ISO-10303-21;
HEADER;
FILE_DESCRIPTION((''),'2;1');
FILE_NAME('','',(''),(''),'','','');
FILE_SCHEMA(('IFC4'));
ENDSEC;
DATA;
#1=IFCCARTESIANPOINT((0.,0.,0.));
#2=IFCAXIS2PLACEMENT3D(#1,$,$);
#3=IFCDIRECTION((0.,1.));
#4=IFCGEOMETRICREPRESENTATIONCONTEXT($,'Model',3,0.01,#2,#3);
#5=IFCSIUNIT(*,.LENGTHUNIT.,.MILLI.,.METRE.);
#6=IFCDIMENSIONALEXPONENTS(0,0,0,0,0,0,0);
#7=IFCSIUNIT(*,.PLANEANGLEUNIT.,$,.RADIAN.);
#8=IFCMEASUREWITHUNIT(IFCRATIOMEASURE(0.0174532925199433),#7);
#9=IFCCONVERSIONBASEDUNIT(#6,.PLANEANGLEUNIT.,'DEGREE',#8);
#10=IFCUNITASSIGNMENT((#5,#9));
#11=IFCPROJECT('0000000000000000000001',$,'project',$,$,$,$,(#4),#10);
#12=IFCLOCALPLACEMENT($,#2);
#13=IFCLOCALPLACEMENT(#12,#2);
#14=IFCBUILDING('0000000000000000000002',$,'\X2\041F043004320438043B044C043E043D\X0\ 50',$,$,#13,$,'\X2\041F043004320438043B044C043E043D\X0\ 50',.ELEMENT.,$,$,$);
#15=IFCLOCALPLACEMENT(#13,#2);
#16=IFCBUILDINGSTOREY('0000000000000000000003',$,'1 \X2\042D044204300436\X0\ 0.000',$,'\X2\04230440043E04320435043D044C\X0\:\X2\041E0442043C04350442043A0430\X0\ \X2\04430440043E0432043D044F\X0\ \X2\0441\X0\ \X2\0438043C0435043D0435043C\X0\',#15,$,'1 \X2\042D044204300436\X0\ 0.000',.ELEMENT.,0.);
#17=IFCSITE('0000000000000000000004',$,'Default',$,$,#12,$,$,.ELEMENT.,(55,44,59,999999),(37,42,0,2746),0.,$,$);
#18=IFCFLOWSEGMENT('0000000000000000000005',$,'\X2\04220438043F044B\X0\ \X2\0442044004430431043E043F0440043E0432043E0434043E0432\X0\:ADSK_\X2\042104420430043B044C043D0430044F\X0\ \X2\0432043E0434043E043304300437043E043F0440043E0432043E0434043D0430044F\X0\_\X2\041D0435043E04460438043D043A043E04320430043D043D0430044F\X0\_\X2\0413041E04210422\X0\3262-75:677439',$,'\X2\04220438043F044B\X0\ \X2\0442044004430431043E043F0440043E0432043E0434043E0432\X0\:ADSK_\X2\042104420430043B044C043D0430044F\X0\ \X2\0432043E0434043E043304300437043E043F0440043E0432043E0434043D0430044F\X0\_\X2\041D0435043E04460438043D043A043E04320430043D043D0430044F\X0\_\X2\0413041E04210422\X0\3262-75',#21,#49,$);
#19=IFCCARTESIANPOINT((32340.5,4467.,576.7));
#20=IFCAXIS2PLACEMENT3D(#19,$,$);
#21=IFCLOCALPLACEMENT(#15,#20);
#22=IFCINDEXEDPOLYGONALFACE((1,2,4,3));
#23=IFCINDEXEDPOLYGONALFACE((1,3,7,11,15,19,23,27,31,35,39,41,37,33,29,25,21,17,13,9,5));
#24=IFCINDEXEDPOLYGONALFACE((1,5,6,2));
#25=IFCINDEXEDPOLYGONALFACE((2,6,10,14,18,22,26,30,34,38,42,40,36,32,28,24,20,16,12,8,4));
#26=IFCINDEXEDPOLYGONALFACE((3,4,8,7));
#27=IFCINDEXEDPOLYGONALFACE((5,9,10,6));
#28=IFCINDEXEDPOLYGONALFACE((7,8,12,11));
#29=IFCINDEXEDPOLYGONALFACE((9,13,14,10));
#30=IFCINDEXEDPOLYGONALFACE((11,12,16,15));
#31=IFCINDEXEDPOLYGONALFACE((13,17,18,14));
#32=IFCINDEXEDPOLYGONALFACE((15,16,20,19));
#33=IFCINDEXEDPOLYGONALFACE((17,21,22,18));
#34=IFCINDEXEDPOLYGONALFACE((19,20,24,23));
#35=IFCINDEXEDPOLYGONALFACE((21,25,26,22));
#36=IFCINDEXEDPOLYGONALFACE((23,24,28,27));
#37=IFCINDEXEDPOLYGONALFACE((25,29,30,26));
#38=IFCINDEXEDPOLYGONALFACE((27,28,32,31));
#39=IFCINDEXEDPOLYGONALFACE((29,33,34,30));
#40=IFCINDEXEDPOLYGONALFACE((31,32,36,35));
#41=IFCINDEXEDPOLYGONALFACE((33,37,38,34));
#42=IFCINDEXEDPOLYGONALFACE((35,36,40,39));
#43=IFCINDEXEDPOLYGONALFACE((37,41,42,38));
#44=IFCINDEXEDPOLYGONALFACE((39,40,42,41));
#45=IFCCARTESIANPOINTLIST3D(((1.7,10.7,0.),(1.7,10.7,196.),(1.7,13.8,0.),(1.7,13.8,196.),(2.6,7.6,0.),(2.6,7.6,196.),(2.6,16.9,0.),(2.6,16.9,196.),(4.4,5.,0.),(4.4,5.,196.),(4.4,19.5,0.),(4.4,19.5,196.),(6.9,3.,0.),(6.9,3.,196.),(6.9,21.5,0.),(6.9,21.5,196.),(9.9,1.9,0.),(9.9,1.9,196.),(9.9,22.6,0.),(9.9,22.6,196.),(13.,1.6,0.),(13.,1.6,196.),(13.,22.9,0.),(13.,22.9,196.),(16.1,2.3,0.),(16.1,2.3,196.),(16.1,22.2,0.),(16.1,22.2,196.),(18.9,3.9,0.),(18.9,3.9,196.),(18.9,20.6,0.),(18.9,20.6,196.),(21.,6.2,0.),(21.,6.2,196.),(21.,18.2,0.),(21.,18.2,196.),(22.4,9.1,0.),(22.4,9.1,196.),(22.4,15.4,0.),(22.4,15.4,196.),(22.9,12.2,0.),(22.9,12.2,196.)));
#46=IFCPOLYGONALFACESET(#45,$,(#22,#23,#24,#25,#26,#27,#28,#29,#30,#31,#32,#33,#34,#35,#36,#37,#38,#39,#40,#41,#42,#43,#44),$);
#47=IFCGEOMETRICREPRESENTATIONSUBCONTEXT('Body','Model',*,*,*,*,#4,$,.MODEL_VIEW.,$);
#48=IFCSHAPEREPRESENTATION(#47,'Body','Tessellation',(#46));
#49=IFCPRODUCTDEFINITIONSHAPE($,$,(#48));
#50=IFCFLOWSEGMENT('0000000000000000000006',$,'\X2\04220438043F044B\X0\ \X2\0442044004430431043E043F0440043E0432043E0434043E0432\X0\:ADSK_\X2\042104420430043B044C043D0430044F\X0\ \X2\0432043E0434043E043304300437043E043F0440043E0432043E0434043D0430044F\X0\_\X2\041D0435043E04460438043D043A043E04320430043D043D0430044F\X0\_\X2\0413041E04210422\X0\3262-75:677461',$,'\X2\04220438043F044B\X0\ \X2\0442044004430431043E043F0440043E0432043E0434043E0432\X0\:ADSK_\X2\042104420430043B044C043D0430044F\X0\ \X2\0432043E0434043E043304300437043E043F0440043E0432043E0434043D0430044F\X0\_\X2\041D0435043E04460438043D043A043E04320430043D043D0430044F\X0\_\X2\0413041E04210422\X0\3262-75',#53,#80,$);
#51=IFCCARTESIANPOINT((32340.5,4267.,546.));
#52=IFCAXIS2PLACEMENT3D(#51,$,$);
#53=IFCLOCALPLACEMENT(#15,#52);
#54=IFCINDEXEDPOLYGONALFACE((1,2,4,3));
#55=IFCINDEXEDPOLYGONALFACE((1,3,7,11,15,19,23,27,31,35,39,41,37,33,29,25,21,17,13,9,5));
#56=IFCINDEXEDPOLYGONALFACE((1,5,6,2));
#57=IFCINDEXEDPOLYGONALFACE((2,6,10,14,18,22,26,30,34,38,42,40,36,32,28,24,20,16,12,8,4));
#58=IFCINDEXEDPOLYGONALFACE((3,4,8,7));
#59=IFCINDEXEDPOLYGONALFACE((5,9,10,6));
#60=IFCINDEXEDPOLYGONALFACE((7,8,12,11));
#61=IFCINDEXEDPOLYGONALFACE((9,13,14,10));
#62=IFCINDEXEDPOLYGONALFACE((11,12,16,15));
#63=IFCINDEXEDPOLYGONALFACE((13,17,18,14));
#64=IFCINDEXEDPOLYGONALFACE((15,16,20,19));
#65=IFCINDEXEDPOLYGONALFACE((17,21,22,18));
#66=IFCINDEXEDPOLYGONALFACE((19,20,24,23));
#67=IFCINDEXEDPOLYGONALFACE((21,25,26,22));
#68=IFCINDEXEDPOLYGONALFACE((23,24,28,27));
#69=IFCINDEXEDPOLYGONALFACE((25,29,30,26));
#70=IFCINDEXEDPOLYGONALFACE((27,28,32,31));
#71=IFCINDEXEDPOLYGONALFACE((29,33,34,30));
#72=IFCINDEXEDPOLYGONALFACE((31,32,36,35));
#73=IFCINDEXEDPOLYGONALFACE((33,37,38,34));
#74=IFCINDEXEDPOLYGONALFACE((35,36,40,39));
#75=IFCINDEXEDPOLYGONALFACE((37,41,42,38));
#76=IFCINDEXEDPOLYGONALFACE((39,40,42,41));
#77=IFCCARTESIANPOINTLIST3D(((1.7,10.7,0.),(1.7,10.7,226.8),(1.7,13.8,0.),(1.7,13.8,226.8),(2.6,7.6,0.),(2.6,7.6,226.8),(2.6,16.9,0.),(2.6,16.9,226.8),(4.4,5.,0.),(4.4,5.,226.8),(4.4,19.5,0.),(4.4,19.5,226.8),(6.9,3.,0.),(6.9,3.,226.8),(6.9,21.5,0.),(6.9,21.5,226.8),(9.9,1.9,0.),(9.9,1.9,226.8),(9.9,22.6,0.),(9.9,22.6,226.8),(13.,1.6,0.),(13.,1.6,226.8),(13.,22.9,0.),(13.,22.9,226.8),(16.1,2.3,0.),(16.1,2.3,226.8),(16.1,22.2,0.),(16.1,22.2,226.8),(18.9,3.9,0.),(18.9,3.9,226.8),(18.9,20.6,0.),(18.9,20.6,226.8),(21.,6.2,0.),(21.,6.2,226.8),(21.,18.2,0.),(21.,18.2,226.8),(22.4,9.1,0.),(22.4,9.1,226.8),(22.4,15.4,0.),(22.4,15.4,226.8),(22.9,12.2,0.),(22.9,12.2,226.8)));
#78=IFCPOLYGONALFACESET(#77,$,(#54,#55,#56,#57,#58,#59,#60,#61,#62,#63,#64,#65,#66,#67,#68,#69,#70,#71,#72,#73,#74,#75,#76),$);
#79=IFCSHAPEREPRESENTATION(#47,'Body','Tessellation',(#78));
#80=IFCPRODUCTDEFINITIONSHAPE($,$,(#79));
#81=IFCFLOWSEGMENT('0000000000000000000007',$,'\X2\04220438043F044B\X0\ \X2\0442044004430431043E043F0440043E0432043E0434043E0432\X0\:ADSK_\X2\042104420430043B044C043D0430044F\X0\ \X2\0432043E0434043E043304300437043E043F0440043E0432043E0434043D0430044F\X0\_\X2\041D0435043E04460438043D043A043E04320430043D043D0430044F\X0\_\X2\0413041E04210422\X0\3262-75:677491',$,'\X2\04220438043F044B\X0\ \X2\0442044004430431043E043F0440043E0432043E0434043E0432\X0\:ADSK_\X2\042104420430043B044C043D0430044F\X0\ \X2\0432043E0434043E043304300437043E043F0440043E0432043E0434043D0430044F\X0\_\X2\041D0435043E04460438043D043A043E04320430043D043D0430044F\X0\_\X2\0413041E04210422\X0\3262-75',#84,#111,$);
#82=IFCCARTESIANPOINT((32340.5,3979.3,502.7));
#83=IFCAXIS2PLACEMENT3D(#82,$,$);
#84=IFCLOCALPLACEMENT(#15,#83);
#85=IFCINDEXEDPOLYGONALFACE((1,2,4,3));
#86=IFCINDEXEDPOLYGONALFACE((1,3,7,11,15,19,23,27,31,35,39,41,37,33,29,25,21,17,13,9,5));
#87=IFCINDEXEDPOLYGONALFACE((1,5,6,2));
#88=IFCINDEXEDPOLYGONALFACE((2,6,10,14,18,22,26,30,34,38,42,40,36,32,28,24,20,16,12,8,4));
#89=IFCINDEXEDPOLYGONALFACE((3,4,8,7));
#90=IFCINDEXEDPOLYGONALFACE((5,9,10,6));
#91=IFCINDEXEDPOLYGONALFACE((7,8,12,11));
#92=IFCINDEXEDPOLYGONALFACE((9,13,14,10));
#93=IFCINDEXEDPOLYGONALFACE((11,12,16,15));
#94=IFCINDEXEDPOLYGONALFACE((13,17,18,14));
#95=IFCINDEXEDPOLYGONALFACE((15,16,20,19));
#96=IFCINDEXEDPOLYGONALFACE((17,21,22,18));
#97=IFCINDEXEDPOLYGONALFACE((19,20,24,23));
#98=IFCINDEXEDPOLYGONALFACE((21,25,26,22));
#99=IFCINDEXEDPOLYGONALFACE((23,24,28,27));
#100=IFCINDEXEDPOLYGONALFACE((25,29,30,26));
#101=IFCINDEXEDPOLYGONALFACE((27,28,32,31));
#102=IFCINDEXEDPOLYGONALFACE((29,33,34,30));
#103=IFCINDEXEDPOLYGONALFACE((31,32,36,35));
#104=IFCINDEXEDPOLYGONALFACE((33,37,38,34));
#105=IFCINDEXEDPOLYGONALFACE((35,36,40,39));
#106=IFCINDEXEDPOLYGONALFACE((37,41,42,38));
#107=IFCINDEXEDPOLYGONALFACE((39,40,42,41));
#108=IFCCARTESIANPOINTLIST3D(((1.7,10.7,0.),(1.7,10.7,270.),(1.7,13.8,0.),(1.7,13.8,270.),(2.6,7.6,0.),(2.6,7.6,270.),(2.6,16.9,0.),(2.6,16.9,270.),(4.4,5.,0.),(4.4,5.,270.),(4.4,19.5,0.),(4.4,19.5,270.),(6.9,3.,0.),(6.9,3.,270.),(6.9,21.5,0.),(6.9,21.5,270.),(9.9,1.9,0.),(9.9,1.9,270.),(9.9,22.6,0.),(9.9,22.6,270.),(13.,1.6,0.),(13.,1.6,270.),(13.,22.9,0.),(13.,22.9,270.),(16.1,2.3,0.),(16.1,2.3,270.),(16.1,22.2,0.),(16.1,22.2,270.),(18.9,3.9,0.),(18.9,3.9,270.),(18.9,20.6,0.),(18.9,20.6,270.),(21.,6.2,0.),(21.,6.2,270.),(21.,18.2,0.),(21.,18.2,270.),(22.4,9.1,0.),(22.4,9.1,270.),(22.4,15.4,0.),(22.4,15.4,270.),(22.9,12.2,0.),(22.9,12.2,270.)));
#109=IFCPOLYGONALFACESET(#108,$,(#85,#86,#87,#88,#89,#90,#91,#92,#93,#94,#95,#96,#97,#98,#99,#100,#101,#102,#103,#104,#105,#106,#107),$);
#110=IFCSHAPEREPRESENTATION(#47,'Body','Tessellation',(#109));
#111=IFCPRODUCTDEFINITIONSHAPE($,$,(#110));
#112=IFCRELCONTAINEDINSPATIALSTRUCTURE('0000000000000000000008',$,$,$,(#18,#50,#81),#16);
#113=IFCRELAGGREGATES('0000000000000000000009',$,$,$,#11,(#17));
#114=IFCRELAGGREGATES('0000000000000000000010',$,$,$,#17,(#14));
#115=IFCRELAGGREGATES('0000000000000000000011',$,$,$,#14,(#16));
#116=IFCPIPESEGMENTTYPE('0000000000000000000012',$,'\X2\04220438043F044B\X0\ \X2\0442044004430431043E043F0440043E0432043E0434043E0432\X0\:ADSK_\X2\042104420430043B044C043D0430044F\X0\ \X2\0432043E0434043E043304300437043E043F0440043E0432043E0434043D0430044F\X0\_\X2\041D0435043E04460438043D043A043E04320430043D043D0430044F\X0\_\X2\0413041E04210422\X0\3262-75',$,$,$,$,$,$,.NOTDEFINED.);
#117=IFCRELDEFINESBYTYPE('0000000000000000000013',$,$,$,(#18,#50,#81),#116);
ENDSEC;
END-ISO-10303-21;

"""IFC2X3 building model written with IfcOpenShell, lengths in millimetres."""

from ifc_helpers import new_model, entity, si_unit, converted_unit, direction, frame, origin, origin_2d_with_axis, place, context, subcontext, project, spatial, circle, extrude, type_object, element, save


model = new_model("IFC2X3")

# Units and contexts
model_context = context("Model", 3, precision=0.01, world=origin(), true_north=direction((0.0, 1.0)))
body_context = subcontext(model_context, "Body", "Model", "MODEL_VIEW")
ifc_project = project(units=[si_unit("LENGTHUNIT", "METRE", prefix="MILLI"), converted_unit("PLANEANGLEUNIT", "DEGREE", entity("IfcRatioMeasure", 0.0174532925199433), si_unit("PLANEANGLEUNIT", "RADIAN"), dimensions=[0, 0, 0, 0, 0, 0, 0])], contexts=[model_context])

# Site, building, storey
site_placement = place(None, origin())
site = spatial("IfcSite", under=ifc_project, at=site_placement, Name="Default", CompositionType="ELEMENT", RefLatitude=(55, 44, 59, 999999), RefLongitude=(37, 42, 0, 2746), RefElevation=0.0)
building_placement = place(site_placement, origin())
building = spatial("IfcBuilding", under=site, at=building_placement, Name="Павильон 50", LongName="Павильон 50", CompositionType="ELEMENT")
storey_placement = place(building_placement, origin())
storey = spatial("IfcBuildingStorey", under=building, at=storey_placement, Name="1 Этаж 0.000", ObjectType="Уровень:Отметка уровня с именем", LongName="1 Этаж 0.000", CompositionType="ELEMENT", Elevation=0.0)

# Flow segments
pipe_segment_type = type_object("IfcPipeSegmentType", Name="Типы трубопроводов:ADSK_Стальная водогазопроводная_Неоцинкованная_ГОСТ3262-75", PredefinedType="NOTDEFINED")
flow_segment_1_placement = place(storey_placement, frame((32340.5, 4467.0, 576.7)))
element("IfcFlowSegment", 1, at=flow_segment_1_placement, inside=storey, type_object=pipe_segment_type, Name="Типы трубопроводов:ADSK_Стальная водогазопроводная_Неоцинкованная_ГОСТ3262-75:677439", ObjectType="Типы трубопроводов:ADSK_Стальная водогазопроводная_Неоцинкованная_ГОСТ3262-75", context=body_context, shape_type="SweptSolid", body=[
    extrude(circle(Radius=10.7, at=origin_2d_with_axis()), frame((12.2, 12.2, 0.0)), (0.0, 0.0, 1.0), 196.0),
])
flow_segment_2_placement = place(storey_placement, frame((32340.5, 4267.0, 546.0)))
element("IfcFlowSegment", 2, at=flow_segment_2_placement, inside=storey, type_object=pipe_segment_type, Name="Типы трубопроводов:ADSK_Стальная водогазопроводная_Неоцинкованная_ГОСТ3262-75:677461", ObjectType="Типы трубопроводов:ADSK_Стальная водогазопроводная_Неоцинкованная_ГОСТ3262-75", context=body_context, shape_type="SweptSolid", body=[
    extrude(circle(Radius=10.7, at=origin_2d_with_axis()), frame((12.2, 12.2, 0.0)), (0.0, 0.0, 1.0), 226.8),
])
flow_segment_3_placement = place(storey_placement, frame((32340.5, 3979.3, 502.7)))
element("IfcFlowSegment", 3, at=flow_segment_3_placement, inside=storey, type_object=pipe_segment_type, Name="Типы трубопроводов:ADSK_Стальная водогазопроводная_Неоцинкованная_ГОСТ3262-75:677491", ObjectType="Типы трубопроводов:ADSK_Стальная водогазопроводная_Неоцинкованная_ГОСТ3262-75", context=body_context, shape_type="SweptSolid", body=[
    extrude(circle(Radius=10.7, at=origin_2d_with_axis()), frame((12.2, 12.2, 0.0)), (0.0, 0.0, 1.0), 270.0),
])

save(model, "model.ifc")
